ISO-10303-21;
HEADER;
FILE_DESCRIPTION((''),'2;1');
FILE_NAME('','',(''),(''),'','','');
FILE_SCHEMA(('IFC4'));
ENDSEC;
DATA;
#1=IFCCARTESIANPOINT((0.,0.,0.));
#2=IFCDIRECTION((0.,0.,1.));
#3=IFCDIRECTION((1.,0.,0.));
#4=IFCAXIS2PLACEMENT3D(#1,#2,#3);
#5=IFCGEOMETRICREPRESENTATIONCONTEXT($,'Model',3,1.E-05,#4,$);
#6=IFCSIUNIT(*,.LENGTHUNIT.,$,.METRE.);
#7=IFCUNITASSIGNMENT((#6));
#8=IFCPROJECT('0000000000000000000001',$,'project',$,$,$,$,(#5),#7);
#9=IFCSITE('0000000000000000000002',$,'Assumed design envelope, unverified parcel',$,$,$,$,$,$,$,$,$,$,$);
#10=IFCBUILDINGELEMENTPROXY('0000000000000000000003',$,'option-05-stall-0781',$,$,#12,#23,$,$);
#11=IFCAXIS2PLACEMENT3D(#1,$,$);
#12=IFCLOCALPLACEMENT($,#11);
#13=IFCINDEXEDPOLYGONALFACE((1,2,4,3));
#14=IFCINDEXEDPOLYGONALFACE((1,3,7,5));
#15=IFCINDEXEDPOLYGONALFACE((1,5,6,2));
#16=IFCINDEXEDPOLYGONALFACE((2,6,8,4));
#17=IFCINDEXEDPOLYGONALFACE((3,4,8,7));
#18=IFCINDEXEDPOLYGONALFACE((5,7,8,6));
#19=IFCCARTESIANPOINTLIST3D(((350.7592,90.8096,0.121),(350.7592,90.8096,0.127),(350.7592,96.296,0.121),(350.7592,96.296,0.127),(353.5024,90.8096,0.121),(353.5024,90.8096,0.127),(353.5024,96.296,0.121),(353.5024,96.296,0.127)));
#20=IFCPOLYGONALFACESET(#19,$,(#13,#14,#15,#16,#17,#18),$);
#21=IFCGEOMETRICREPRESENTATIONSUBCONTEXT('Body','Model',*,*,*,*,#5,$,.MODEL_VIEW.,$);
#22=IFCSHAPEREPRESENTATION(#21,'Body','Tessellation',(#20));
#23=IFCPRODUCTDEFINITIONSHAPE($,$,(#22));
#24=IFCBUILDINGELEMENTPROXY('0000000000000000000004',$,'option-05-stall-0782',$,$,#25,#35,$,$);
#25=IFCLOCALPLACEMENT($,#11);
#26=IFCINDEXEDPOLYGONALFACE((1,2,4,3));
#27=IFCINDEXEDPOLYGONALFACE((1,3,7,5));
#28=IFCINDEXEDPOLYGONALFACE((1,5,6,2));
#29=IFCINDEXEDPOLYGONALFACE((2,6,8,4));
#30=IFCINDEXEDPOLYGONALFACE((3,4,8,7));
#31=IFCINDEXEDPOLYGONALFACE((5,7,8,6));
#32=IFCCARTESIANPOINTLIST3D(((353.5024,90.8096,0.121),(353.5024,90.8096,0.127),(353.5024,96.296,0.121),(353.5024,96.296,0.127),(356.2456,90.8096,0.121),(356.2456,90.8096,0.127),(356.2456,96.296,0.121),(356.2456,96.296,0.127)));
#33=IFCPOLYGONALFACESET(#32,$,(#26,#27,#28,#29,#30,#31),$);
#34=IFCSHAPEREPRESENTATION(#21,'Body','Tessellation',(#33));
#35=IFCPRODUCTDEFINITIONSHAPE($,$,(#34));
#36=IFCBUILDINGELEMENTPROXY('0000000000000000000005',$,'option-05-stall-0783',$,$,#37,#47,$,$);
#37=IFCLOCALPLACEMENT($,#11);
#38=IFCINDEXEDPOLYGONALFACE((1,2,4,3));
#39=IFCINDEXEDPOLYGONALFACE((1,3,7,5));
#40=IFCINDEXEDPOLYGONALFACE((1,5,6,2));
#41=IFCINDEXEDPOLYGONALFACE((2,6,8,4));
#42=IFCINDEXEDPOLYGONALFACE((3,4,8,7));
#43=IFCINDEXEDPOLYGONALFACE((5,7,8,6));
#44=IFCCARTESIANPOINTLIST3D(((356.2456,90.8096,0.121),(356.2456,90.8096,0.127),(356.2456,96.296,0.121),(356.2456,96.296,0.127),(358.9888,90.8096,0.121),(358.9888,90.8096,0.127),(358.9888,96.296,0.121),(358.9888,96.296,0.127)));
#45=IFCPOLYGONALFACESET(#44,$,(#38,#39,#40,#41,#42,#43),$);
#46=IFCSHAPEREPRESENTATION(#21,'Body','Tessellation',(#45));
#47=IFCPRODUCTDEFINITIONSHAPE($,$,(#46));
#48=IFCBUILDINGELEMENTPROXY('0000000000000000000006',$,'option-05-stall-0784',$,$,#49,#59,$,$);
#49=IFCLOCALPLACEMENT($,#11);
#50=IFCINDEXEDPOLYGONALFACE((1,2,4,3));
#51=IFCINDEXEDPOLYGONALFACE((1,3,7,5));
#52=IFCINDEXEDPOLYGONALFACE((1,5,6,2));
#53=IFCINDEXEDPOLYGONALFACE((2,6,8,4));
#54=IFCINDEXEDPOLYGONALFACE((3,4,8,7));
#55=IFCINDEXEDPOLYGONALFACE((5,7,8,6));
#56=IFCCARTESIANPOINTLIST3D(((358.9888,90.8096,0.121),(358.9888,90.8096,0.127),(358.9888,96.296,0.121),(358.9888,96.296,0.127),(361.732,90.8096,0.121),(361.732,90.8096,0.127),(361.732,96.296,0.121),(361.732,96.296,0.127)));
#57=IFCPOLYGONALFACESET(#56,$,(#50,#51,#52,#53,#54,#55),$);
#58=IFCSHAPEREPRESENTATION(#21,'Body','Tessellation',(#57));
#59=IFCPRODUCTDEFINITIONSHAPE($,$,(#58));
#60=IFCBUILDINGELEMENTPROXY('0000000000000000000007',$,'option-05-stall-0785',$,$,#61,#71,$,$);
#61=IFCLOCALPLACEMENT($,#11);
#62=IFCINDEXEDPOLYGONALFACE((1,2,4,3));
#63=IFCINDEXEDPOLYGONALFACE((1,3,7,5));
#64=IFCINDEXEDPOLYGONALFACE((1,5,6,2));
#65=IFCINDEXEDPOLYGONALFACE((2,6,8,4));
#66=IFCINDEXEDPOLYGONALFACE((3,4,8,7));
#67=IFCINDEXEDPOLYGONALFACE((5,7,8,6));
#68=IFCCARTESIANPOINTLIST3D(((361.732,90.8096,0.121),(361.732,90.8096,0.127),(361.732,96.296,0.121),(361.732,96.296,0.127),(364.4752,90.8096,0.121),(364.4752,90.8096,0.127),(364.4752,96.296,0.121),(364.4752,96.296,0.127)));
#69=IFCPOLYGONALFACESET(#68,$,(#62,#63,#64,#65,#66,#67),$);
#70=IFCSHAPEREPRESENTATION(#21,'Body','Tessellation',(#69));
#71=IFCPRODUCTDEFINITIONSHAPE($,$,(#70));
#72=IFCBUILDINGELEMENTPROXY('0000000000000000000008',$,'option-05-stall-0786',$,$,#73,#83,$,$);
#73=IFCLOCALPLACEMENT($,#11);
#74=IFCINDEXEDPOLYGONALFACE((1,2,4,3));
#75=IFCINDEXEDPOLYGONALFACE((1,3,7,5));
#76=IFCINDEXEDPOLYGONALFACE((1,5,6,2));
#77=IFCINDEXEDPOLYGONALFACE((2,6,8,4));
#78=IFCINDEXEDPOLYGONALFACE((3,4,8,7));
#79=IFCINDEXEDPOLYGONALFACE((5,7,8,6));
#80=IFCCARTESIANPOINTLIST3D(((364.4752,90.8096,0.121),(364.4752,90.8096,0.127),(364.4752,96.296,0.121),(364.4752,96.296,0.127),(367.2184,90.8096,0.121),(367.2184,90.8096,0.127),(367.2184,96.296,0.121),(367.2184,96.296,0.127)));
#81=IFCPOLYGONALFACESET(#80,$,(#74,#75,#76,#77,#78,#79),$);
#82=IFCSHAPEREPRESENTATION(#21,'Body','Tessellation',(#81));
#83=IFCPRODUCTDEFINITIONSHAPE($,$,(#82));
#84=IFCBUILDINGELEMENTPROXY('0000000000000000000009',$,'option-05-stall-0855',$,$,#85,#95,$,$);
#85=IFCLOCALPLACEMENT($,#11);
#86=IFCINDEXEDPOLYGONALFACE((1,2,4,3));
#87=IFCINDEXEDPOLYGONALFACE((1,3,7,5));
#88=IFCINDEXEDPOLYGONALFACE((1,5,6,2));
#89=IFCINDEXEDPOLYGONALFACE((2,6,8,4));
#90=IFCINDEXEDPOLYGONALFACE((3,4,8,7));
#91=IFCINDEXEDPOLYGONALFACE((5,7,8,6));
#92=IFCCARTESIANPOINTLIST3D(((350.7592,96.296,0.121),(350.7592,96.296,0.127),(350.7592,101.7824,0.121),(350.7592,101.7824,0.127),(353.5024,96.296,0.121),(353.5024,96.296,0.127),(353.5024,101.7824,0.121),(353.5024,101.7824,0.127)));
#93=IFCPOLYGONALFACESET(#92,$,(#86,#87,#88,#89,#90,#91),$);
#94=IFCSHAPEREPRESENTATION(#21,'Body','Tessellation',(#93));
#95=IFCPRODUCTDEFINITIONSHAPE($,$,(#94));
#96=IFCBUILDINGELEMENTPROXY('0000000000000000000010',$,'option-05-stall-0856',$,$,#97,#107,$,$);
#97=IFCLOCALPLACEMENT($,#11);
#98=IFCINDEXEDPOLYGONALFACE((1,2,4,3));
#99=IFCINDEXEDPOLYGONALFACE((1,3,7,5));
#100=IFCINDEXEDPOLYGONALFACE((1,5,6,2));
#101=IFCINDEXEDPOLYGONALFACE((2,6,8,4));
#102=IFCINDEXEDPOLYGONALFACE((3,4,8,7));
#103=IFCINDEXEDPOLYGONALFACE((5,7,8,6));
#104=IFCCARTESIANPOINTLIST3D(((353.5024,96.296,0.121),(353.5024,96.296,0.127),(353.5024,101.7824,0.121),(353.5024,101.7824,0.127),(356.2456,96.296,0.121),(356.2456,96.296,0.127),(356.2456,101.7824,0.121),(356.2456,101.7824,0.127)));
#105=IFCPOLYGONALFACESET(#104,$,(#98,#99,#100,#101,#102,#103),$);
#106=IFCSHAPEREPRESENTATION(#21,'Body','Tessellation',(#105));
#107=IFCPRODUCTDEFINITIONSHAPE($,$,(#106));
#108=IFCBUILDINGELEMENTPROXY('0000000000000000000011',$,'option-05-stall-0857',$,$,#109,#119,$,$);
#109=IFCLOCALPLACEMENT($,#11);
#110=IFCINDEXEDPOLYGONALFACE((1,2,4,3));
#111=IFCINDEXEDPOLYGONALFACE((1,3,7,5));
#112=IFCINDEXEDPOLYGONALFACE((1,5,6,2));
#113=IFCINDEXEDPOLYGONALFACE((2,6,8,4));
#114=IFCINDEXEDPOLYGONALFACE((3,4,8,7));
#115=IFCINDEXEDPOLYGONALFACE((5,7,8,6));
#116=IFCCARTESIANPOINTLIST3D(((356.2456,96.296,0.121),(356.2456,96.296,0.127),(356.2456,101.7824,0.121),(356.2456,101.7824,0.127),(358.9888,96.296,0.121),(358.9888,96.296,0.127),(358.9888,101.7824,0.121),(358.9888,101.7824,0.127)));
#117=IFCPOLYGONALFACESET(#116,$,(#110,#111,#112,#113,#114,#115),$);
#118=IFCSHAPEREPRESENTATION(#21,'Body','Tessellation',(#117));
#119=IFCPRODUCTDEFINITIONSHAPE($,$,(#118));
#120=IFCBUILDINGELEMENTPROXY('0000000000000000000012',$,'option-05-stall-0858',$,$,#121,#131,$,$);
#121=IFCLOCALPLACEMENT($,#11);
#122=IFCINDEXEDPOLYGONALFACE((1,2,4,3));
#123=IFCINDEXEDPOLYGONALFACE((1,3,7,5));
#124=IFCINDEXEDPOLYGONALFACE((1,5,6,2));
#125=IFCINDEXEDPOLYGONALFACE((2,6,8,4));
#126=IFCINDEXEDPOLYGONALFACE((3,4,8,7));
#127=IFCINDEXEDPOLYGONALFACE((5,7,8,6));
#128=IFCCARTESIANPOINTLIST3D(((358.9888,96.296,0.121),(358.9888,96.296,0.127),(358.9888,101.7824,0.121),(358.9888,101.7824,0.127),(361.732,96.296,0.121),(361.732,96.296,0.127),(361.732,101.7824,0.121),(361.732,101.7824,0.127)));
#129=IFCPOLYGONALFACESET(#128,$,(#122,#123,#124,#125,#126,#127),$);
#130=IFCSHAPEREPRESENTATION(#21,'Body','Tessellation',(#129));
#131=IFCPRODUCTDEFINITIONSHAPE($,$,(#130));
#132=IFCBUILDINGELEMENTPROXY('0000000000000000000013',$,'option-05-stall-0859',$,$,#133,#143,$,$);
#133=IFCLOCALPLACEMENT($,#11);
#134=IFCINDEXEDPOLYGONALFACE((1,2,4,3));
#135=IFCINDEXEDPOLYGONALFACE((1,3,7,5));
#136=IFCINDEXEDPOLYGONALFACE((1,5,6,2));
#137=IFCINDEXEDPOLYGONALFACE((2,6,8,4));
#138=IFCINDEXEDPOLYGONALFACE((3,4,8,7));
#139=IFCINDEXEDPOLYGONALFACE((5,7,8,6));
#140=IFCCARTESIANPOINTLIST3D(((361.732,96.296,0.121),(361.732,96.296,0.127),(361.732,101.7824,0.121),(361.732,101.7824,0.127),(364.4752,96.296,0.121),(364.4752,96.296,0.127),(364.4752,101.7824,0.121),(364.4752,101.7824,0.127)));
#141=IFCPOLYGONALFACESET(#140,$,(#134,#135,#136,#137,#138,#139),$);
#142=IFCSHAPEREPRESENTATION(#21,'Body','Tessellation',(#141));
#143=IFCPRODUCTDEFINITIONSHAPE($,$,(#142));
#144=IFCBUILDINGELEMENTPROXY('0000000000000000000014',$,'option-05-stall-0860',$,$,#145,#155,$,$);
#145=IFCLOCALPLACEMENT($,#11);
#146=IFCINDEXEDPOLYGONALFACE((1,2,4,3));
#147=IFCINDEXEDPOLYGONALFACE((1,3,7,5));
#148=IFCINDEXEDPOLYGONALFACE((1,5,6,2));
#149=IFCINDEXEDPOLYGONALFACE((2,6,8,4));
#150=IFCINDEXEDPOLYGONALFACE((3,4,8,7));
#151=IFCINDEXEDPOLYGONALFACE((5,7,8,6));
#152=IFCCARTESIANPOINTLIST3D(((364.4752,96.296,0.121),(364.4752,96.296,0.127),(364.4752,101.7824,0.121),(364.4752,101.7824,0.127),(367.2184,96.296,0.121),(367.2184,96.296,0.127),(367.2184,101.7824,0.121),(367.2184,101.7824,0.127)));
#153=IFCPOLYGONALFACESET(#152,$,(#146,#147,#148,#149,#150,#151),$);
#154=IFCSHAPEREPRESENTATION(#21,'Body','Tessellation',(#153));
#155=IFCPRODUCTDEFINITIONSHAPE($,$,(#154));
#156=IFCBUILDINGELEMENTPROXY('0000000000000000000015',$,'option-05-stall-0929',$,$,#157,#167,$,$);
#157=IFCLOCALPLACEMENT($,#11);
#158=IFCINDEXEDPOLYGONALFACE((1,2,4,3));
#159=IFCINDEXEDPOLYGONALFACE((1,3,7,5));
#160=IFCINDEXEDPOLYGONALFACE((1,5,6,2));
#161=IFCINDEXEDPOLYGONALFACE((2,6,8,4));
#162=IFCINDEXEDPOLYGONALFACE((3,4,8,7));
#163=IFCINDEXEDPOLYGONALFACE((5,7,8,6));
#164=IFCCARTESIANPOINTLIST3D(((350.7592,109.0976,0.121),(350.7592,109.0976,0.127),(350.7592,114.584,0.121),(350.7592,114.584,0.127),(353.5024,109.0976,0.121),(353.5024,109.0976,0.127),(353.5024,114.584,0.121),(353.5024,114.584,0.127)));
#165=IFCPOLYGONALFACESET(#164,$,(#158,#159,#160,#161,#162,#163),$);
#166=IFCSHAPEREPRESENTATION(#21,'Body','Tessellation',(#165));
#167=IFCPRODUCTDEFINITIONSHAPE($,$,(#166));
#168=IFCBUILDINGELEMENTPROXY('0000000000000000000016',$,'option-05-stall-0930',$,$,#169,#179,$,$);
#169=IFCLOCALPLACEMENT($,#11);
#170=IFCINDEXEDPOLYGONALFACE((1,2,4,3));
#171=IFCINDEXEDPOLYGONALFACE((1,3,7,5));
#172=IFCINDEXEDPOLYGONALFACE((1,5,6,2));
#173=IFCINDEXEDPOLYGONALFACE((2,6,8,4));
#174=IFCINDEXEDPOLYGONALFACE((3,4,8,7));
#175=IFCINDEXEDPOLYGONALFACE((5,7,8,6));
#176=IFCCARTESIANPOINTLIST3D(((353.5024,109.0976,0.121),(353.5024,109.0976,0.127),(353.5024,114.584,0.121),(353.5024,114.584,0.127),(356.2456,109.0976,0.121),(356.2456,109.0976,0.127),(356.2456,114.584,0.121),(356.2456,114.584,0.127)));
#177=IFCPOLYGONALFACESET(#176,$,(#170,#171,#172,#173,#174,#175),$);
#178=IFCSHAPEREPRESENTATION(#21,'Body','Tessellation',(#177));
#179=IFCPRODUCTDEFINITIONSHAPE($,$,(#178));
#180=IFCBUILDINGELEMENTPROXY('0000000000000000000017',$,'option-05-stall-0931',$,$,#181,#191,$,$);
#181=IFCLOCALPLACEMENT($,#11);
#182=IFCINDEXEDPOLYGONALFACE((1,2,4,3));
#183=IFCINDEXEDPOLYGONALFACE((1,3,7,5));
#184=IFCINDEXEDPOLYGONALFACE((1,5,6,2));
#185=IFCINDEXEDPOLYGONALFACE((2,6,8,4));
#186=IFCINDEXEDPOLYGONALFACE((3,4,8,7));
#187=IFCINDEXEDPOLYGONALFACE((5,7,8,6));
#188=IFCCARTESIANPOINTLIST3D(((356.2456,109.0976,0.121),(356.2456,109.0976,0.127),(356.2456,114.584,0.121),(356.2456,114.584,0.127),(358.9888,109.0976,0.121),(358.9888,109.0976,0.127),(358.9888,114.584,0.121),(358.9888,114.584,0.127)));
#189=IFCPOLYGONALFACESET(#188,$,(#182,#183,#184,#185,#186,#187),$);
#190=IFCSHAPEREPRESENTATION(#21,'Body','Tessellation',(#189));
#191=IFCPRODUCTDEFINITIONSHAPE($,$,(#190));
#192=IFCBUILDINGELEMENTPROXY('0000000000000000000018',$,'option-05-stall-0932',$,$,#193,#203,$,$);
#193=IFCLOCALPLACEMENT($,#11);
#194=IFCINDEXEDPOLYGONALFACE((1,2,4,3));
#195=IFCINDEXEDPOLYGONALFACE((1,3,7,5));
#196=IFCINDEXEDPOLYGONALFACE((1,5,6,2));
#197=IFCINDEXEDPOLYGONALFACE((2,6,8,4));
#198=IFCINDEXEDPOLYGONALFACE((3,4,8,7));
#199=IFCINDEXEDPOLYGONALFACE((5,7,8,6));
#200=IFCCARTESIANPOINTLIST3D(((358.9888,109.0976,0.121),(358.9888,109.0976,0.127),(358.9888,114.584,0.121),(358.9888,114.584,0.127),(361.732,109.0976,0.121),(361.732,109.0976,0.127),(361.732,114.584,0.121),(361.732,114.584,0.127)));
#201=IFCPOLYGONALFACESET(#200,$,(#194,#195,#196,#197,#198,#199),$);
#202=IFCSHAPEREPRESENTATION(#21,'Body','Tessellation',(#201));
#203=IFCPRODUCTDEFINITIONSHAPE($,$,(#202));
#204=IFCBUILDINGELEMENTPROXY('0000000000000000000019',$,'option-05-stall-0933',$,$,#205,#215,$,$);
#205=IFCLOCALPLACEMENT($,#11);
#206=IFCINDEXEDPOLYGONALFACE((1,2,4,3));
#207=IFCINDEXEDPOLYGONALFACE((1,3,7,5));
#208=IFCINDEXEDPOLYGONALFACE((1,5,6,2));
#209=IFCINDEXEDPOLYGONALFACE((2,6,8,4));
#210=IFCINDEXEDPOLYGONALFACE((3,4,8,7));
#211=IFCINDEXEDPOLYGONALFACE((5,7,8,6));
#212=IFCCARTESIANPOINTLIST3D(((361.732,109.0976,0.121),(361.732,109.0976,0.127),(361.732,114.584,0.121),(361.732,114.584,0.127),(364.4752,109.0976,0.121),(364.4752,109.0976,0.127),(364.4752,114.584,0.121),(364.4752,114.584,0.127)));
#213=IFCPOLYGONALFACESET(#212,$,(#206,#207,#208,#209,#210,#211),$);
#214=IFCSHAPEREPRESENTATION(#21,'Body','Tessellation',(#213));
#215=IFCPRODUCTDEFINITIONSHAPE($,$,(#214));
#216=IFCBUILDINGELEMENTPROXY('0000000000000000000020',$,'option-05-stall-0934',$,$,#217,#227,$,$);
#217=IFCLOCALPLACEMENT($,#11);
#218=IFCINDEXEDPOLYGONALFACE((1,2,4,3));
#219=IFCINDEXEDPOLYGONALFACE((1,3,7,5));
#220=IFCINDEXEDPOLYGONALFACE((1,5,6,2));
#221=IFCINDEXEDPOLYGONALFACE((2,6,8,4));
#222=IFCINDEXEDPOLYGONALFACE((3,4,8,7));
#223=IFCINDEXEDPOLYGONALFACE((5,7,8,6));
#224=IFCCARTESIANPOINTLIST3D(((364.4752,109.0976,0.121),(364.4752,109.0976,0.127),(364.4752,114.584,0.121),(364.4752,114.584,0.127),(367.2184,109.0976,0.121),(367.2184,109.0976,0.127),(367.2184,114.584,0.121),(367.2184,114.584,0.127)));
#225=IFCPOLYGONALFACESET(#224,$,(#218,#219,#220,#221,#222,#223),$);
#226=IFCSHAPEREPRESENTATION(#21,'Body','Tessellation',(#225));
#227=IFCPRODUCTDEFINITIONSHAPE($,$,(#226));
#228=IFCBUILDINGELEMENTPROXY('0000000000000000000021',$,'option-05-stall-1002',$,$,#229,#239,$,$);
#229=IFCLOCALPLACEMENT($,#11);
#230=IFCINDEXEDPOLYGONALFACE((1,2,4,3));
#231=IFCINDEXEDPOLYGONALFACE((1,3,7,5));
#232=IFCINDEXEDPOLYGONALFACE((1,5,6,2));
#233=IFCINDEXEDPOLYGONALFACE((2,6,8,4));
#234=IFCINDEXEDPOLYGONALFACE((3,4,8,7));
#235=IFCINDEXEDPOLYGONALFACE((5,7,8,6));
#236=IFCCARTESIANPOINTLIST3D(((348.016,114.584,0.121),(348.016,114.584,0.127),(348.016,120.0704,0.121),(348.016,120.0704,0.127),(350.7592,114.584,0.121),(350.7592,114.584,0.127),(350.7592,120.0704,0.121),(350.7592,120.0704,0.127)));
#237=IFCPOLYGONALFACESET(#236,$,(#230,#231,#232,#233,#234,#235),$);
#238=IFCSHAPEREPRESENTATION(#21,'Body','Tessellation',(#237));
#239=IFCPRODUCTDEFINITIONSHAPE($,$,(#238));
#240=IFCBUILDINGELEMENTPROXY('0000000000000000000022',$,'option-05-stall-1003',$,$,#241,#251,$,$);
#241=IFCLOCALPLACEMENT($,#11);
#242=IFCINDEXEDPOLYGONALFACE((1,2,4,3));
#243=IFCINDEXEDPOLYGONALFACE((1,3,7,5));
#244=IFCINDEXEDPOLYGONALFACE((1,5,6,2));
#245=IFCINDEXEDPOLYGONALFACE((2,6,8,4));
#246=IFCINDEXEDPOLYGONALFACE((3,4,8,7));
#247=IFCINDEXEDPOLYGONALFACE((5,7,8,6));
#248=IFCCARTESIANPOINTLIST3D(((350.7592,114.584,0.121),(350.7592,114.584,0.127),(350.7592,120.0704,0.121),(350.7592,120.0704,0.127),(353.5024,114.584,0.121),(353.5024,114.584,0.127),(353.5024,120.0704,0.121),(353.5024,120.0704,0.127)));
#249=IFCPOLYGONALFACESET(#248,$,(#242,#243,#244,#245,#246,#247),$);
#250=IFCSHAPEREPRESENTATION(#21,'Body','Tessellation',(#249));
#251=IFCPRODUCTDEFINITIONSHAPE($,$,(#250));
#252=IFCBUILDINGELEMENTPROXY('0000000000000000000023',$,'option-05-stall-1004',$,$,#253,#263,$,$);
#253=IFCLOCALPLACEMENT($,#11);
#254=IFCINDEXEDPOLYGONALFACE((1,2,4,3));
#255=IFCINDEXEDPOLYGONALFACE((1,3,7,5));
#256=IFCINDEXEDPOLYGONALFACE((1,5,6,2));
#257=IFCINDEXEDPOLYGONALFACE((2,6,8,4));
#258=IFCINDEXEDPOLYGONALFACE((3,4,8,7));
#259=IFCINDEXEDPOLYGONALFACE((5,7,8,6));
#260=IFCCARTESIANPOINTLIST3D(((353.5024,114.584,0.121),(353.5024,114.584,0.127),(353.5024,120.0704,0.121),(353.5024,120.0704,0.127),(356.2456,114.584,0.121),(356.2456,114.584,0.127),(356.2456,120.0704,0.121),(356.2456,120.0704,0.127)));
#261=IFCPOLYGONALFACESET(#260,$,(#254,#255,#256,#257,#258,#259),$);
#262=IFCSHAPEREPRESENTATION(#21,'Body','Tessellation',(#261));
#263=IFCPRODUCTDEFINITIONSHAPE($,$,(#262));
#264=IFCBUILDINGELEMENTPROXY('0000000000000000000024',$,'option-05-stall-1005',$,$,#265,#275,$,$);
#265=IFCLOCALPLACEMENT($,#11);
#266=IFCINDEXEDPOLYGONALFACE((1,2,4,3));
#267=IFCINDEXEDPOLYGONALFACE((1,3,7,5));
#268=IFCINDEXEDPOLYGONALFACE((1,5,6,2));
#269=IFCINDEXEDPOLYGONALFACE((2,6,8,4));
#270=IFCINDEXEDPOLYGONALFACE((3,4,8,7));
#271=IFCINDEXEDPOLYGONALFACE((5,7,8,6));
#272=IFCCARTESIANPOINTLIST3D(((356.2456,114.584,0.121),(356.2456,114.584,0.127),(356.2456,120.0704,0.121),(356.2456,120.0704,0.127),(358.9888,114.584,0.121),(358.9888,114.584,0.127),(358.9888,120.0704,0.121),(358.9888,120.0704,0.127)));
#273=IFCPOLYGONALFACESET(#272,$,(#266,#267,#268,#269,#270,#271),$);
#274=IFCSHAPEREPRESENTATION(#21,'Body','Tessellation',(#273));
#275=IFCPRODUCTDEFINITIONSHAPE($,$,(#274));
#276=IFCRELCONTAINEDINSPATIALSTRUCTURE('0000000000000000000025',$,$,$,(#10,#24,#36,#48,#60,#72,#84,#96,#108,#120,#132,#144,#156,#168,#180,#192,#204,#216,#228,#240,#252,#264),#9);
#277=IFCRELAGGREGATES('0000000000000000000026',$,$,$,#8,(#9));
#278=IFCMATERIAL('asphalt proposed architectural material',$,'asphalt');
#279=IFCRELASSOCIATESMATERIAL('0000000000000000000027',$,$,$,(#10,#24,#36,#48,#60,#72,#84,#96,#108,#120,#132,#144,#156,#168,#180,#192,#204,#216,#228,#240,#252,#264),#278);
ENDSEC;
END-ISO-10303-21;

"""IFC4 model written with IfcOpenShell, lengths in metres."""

from ifc_helpers import new_model, si_unit, frame, origin_with_axes, place, context, subcontext, project, spatial, rectangle, extrude, material, element, save


model = new_model("IFC4")

# Units and contexts
model_context = context("Model", 3, precision=1e-05, world=origin_with_axes())
body_context = subcontext(model_context, "Body", "Model", "MODEL_VIEW")
ifc_project = project(units=[si_unit("LENGTHUNIT", "METRE")], contexts=[model_context])

# Site
site = spatial("IfcSite", under=ifc_project, Name="Assumed design envelope, unverified parcel")

# Building element proxies
ifc_material = material(Name="asphalt proposed architectural material", Category="asphalt")
for number, where, z_axis, x_axis, name in (
    (1, (352.1308, 93.5528, 0.121), (0.0, 0.0, 1.0), (1.0, 0.0, 0.0), "option-05-stall-0781"),
    (2, (354.874, 93.5528, 0.121), (0.0, 0.0, 1.0), (1.0, 0.0, 0.0), "option-05-stall-0782"),
    (3, (357.6172, 93.5528, 0.121), (0.0, 0.0, 1.0), (1.0, 0.0, 0.0), "option-05-stall-0783"),
    (4, (360.3604, 93.5528, 0.121), (0.0, 0.0, 1.0), (1.0, 0.0, 0.0), "option-05-stall-0784"),
    (5, (363.1036, 93.5528, 0.121), (0.0, 0.0, 1.0), (1.0, 0.0, 0.0), "option-05-stall-0785"),
    (6, (365.8468, 93.5528, 0.121), (0.0, 0.0, 1.0), (1.0, 0.0, 0.0), "option-05-stall-0786"),
    (7, (352.1308, 99.0392, 0.121), (0.0, 0.0, 1.0), (1.0, 0.0, 0.0), "option-05-stall-0855"),
    (8, (354.874, 99.0392, 0.121), (0.0, 0.0, 1.0), (1.0, 0.0, 0.0), "option-05-stall-0856"),
    (9, (357.6172, 99.0392, 0.121), (0.0, 0.0, 1.0), (1.0, 0.0, 0.0), "option-05-stall-0857"),
    (10, (360.3604, 99.0392, 0.121), (0.0, 0.0, 1.0), (1.0, 0.0, 0.0), "option-05-stall-0858"),
    (11, (363.1036, 99.0392, 0.121), (0.0, 0.0, 1.0), (1.0, 0.0, 0.0), "option-05-stall-0859"),
    (12, (365.8468, 99.0392, 0.121), (0.0, 0.0, 1.0), (1.0, 0.0, 0.0), "option-05-stall-0860"),
    (13, (352.1308, 111.8408, 0.121), (0.0, 0.0, 1.0), (1.0, 0.0, 0.0), "option-05-stall-0929"),
    (14, (354.874, 111.8408, 0.121), (0.0, 0.0, 1.0), (1.0, 0.0, 0.0), "option-05-stall-0930"),
    (15, (357.6172, 111.8408, 0.121), (0.0, 0.0, 1.0), (1.0, 0.0, 0.0), "option-05-stall-0931"),
    (16, (360.3604, 111.8408, 0.121), (0.0, 0.0, 1.0), (1.0, 0.0, 0.0), "option-05-stall-0932"),
    (17, (363.1036, 111.8408, 0.121), (0.0, 0.0, 1.0), (1.0, 0.0, 0.0), "option-05-stall-0933"),
    (18, (365.8468, 111.8408, 0.121), (0.0, 0.0, 1.0), (1.0, 0.0, 0.0), "option-05-stall-0934"),
    (19, (349.3876, 117.3272, 0.121), (0.0, 0.0, 1.0), (1.0, 0.0, 0.0), "option-05-stall-1002"),
    (20, (352.1308, 117.3272, 0.121), (0.0, 0.0, 1.0), (1.0, 0.0, 0.0), "option-05-stall-1003"),
    (21, (354.874, 117.3272, 0.121), (0.0, 0.0, 1.0), (1.0, 0.0, 0.0), "option-05-stall-1004"),
    (22, (357.6172, 117.3272, 0.121), (0.0, 0.0, 1.0), (1.0, 0.0, 0.0), "option-05-stall-1005"),
):
    element("IfcBuildingElementProxy", number, at=place(None, frame(where, z_axis=z_axis, x_axis=x_axis)), inside=site, material=ifc_material, Name=name, context=body_context, shape_type="SweptSolid", body=[
        extrude(rectangle(XDim=2.7432, YDim=5.4864), origin_with_axes(), (0.0, 0.0, 1.0), 0.006),
    ])

save(model, "model.ifc")
